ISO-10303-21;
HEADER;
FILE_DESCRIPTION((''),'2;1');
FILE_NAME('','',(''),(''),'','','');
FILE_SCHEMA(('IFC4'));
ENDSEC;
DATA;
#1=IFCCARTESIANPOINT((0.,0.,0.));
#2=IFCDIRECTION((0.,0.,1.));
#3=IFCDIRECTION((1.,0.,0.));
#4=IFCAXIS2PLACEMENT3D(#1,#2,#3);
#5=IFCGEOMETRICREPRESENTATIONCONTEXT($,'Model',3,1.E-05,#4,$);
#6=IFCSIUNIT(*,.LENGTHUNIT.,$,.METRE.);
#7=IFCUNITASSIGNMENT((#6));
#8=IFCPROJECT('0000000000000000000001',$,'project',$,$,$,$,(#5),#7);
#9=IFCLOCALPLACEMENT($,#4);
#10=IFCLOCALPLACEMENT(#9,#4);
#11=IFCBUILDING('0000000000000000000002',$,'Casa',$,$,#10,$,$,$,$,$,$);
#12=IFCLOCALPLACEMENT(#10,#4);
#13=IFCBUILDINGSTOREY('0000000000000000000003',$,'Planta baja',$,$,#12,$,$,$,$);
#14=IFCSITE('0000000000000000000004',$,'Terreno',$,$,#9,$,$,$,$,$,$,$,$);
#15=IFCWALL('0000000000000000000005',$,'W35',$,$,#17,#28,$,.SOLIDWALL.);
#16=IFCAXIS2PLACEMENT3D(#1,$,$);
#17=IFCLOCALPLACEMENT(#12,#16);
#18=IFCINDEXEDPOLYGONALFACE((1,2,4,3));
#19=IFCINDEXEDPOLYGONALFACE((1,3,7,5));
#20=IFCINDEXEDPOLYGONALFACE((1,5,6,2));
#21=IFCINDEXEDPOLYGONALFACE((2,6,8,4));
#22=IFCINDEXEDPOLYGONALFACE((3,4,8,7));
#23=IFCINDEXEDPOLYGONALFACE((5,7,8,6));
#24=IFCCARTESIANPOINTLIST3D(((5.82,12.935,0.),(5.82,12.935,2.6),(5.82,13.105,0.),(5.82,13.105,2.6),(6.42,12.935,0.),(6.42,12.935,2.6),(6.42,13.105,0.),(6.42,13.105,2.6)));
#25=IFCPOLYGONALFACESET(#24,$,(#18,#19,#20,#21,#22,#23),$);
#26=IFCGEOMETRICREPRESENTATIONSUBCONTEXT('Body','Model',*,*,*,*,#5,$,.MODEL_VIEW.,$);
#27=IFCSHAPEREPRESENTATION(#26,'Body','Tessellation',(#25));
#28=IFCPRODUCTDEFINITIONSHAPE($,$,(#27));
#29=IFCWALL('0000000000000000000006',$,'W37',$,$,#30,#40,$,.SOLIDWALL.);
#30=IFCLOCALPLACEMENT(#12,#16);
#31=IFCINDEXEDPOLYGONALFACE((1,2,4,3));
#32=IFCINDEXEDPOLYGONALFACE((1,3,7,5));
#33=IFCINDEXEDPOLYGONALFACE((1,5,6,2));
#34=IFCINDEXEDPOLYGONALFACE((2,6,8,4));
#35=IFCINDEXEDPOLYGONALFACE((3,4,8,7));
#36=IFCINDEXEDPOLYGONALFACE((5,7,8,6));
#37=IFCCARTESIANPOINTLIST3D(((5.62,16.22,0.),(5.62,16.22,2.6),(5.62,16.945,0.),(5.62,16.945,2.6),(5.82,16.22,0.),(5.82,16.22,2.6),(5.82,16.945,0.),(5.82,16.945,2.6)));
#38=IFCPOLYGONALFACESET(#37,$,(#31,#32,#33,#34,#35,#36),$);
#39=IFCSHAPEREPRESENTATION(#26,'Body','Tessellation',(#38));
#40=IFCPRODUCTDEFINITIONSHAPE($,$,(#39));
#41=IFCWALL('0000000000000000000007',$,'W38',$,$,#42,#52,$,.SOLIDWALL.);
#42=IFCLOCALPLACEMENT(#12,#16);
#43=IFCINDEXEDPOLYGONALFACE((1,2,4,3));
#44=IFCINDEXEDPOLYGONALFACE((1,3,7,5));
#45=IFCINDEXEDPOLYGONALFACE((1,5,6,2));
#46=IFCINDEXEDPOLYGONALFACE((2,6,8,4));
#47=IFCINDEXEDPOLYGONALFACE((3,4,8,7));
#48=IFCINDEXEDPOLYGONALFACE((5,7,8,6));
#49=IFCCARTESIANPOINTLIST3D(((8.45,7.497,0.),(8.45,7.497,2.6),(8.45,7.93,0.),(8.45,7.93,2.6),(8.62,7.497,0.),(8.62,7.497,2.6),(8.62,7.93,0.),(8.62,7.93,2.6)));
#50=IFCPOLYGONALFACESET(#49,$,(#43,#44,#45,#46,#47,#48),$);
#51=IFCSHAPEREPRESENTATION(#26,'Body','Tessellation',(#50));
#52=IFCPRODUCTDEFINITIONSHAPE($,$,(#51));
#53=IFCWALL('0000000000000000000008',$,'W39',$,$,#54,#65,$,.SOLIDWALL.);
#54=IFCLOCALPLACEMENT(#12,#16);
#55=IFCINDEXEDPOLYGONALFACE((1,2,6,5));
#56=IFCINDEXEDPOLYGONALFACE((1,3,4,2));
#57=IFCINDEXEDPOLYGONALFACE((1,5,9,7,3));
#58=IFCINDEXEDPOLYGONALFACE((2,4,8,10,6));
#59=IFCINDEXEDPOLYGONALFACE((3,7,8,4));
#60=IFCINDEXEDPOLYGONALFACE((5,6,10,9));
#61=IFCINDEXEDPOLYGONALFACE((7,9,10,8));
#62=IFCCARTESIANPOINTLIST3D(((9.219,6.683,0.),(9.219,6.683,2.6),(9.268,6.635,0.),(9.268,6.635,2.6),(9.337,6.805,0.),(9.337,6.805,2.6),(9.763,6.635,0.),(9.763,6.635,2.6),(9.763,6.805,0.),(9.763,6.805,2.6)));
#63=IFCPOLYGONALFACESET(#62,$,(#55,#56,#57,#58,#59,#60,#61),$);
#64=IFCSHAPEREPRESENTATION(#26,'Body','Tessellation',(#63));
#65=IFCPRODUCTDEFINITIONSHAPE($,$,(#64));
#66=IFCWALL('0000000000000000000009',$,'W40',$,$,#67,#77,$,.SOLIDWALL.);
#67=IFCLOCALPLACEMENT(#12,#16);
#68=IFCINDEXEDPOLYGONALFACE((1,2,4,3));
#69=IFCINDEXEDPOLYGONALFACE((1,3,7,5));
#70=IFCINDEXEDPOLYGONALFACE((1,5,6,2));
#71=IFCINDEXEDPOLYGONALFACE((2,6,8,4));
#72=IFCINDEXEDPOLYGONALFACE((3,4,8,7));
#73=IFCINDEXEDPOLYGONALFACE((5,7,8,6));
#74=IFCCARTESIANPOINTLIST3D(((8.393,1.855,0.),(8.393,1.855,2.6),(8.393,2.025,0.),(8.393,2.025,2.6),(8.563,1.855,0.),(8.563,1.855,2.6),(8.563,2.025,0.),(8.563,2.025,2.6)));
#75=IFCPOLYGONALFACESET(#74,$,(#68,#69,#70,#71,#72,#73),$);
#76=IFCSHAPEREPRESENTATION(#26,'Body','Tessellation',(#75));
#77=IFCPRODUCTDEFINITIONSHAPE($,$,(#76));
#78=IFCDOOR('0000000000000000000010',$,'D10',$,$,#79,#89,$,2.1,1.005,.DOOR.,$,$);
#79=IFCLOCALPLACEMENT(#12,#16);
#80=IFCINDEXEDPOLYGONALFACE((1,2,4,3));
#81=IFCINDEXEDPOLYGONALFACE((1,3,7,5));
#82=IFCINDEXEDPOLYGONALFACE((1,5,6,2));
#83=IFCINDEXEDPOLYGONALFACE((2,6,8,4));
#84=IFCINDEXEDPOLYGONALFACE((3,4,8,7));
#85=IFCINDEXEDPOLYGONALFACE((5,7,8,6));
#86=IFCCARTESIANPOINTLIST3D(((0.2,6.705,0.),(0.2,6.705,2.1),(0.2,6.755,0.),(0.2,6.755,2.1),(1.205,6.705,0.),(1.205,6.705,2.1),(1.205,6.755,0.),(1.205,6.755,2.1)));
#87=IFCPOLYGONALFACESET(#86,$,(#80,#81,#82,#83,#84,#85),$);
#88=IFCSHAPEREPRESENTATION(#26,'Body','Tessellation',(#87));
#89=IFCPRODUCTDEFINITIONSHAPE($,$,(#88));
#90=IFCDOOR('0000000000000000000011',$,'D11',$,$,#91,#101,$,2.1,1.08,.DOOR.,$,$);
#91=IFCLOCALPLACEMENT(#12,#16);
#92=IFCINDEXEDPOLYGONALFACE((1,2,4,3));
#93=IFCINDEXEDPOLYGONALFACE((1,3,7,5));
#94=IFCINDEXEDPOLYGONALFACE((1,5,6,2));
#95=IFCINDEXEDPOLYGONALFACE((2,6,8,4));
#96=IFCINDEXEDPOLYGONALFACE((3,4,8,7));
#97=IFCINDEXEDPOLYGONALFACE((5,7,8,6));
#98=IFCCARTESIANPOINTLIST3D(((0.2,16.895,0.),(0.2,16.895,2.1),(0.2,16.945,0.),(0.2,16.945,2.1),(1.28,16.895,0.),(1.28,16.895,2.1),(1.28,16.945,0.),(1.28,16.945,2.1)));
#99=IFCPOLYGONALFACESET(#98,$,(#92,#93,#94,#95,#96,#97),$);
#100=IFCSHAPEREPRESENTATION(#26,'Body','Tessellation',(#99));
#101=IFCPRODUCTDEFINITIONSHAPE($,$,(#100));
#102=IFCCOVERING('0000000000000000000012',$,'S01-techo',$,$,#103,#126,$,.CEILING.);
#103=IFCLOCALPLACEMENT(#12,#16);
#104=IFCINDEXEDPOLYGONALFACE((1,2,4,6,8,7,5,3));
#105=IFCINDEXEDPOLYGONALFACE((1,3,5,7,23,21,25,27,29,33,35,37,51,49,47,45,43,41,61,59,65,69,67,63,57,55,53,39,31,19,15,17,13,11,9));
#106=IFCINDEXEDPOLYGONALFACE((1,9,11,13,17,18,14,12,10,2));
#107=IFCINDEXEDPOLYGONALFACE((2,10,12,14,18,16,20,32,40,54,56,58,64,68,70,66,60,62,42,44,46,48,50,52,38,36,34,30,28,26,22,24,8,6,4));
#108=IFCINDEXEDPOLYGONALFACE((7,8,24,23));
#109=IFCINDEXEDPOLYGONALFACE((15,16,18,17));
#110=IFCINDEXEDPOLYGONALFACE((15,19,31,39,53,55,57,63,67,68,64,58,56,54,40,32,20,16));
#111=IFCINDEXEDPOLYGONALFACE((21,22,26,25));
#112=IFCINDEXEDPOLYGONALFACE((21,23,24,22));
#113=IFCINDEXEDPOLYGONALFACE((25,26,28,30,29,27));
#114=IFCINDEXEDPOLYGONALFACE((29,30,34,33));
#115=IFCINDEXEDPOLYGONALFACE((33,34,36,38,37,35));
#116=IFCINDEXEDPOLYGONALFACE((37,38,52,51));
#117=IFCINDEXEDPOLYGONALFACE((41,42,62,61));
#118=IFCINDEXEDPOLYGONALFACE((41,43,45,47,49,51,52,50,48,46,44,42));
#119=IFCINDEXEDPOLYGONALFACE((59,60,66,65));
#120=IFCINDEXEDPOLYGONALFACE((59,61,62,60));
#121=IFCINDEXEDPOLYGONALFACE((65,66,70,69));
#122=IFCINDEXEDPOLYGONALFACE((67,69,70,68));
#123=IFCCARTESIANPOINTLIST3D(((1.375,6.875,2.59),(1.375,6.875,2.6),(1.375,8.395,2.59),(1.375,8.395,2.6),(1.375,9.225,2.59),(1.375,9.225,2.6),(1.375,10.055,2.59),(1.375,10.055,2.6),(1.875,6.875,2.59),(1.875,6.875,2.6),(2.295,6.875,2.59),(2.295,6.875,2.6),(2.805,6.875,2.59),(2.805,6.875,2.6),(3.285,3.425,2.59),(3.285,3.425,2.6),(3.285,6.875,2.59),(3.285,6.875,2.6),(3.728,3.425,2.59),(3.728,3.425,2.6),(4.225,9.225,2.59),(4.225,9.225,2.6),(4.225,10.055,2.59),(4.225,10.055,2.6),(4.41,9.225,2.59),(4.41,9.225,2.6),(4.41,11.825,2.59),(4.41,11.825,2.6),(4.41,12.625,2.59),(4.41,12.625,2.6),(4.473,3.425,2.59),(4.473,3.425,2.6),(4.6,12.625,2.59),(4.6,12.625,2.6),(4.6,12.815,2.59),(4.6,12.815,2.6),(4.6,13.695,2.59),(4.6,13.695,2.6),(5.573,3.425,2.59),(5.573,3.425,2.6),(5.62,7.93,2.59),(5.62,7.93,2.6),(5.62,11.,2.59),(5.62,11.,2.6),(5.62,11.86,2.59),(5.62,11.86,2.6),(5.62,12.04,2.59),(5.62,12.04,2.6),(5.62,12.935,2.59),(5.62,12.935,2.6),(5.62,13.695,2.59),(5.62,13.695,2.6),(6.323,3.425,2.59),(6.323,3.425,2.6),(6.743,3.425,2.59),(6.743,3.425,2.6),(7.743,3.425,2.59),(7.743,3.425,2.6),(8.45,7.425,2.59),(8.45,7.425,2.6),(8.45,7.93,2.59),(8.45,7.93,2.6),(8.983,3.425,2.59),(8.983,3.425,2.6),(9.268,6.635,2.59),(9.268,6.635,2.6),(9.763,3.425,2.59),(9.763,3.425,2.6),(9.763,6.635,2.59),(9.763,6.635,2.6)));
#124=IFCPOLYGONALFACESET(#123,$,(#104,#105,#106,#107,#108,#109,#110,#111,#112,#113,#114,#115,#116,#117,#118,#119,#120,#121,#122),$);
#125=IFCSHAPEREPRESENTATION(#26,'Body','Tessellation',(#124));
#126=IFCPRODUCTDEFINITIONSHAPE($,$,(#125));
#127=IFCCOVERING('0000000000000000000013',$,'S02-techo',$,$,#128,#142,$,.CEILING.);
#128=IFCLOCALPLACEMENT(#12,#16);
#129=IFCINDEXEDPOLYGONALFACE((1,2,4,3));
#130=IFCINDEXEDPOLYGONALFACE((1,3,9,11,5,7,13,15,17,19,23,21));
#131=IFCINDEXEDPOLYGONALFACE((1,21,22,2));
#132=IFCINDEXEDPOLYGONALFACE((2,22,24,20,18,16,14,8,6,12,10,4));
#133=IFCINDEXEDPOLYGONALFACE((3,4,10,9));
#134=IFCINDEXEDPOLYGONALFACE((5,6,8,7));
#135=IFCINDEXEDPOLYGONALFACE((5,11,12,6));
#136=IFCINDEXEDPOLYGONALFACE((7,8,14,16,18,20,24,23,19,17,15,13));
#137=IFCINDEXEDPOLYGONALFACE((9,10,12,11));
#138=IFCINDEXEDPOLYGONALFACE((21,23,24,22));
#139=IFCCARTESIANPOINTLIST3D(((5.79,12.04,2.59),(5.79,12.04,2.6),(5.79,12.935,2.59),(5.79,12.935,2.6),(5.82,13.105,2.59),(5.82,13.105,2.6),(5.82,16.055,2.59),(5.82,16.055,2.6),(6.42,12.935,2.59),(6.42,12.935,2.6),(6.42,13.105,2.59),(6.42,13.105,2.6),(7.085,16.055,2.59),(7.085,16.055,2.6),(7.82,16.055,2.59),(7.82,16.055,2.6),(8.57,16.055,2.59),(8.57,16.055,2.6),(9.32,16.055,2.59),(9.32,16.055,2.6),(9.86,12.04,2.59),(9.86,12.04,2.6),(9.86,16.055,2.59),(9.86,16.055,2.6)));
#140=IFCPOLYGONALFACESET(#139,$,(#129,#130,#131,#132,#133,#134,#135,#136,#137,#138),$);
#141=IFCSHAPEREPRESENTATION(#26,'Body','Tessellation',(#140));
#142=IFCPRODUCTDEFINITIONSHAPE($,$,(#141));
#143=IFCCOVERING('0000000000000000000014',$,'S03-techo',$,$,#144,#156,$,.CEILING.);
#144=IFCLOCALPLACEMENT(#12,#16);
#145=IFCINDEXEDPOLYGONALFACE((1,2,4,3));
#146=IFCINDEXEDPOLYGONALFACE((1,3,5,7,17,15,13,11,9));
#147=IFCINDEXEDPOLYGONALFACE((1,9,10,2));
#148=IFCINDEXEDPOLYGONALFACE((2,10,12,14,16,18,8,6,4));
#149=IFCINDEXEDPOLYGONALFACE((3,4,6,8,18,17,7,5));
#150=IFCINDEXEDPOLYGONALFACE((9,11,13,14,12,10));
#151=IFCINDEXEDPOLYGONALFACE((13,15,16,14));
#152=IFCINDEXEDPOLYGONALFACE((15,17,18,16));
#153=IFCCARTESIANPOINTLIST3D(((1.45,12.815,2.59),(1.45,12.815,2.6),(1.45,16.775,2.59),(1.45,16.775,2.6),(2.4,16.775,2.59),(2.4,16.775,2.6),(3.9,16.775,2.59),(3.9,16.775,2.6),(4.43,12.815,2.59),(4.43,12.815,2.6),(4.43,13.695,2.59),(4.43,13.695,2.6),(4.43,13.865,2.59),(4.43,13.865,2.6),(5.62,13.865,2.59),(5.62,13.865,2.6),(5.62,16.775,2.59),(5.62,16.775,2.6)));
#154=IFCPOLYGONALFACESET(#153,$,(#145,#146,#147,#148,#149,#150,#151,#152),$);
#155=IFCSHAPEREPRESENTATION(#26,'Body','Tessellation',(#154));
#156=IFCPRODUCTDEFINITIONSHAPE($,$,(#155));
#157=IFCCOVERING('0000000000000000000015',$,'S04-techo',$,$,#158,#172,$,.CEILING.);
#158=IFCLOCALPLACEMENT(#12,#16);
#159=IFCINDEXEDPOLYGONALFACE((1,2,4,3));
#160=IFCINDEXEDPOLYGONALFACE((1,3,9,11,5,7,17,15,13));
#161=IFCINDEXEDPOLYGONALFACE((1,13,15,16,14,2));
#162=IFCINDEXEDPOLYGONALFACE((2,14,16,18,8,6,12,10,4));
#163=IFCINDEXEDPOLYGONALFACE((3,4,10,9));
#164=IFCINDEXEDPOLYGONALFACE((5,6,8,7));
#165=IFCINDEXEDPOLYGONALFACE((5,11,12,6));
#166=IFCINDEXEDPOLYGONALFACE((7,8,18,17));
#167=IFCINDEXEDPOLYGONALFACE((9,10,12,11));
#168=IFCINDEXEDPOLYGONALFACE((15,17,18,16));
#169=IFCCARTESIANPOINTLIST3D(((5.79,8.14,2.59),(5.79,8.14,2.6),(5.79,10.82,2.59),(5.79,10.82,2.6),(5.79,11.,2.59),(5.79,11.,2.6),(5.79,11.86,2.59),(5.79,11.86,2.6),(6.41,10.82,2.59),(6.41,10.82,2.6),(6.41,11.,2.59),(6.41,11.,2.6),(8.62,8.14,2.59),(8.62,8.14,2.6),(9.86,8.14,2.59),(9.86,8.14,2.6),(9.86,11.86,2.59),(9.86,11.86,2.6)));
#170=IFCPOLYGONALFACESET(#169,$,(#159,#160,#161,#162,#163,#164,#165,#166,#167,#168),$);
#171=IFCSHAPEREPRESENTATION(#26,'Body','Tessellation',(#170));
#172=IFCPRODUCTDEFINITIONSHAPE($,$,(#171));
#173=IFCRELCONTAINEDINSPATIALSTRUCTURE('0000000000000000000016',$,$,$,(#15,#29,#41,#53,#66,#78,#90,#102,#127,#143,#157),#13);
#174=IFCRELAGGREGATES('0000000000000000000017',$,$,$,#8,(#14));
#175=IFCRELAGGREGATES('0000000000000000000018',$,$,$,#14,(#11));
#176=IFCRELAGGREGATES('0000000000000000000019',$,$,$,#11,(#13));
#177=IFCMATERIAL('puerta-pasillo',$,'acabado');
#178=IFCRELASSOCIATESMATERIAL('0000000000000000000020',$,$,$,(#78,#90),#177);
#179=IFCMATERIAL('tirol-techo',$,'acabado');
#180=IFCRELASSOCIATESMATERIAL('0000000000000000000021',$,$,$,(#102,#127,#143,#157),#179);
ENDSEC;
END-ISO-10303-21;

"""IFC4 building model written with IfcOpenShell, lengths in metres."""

from ifc_helpers import new_model, si_unit, frame, origin_with_axes, place, context, subcontext, project, spatial, line, indexed_curve, outline, extrude, material, element, save


model = new_model("IFC4")

# Units and contexts
model_context = context("Model", 3, precision=1e-05, world=origin_with_axes())
body_context = subcontext(model_context, "Body", "Model", "MODEL_VIEW")
ifc_project = project(units=[si_unit("LENGTHUNIT", "METRE")], contexts=[model_context])

# Site, building, storey
site_placement = place(None, origin_with_axes())
site = spatial("IfcSite", under=ifc_project, at=site_placement, Name="Terreno")
building_placement = place(site_placement, origin_with_axes())
building = spatial("IfcBuilding", under=site, at=building_placement, Name="Casa")
storey_placement = place(building_placement, origin_with_axes())
storey = spatial("IfcBuildingStorey", under=building, at=storey_placement, Name="Planta baja")

# Walls
wall_1_placement = place(storey_placement, origin_with_axes())
element("IfcWall", 1, at=wall_1_placement, inside=storey, Name="W35", PredefinedType="SOLIDWALL", context=body_context, shape_type="SweptSolid", body=[
    extrude(outline(indexed_curve([(6.42, 13.105), (6.42, 12.935), (5.82, 12.935), (5.82, 13.105)], segments=[line(1, 2, 3, 4, 1)])), origin_with_axes(), (0.0, 0.0, 1.0), 2.6),
])
wall_2_placement = place(storey_placement, origin_with_axes())
element("IfcWall", 2, at=wall_2_placement, inside=storey, Name="W37", PredefinedType="SOLIDWALL", context=body_context, shape_type="SweptSolid", body=[
    extrude(outline(indexed_curve([(5.62, 16.945), (5.82, 16.945), (5.82, 16.22), (5.62, 16.22)], segments=[line(1, 2, 3, 4, 1)])), origin_with_axes(), (0.0, 0.0, 1.0), 2.6),
])
wall_3_placement = place(storey_placement, origin_with_axes())
element("IfcWall", 3, at=wall_3_placement, inside=storey, Name="W38", PredefinedType="SOLIDWALL", context=body_context, shape_type="SweptSolid", body=[
    extrude(outline(indexed_curve([(8.62, 7.93), (8.62, 7.497), (8.45, 7.497), (8.45, 7.93)], segments=[line(1, 2, 3, 4, 1)])), origin_with_axes(), (0.0, 0.0, 1.0), 2.6),
])
wall_4_placement = place(storey_placement, origin_with_axes())
element("IfcWall", 4, at=wall_4_placement, inside=storey, Name="W39", PredefinedType="SOLIDWALL", context=body_context, shape_type="SweptSolid", body=[
    extrude(outline(indexed_curve([(9.337, 6.805), (9.763, 6.805), (9.763, 6.635), (9.268, 6.635), (9.219, 6.683)], segments=[line(1, 2, 3, 4, 5, 1)])), origin_with_axes(), (0.0, 0.0, 1.0), 2.6),
])
wall_5_placement = place(storey_placement, origin_with_axes())
element("IfcWall", 5, at=wall_5_placement, inside=storey, Name="W40", PredefinedType="SOLIDWALL", context=body_context, shape_type="SweptSolid", body=[
    extrude(outline(indexed_curve([(8.563, 1.855), (8.393, 1.855), (8.393, 2.025), (8.563, 2.025)], segments=[line(1, 2, 3, 4, 1)])), origin_with_axes(), (0.0, 0.0, 1.0), 2.6),
])

# Doors
ifc_material_1 = material(Name="puerta-pasillo", Category="acabado")
door_1_placement = place(storey_placement, origin_with_axes())
element("IfcDoor", 6, at=door_1_placement, inside=storey, material=ifc_material_1, Name="D10", OverallHeight=2.1, OverallWidth=1.005, PredefinedType="DOOR", context=body_context, shape_type="SweptSolid", body=[
    extrude(outline(indexed_curve([(0.2, 6.705), (1.205, 6.705), (1.205, 6.755), (0.2, 6.755)], segments=[line(1, 2, 3, 4, 1)])), origin_with_axes(), (0.0, 0.0, 1.0), 2.1),
])
door_2_placement = place(storey_placement, origin_with_axes())
element("IfcDoor", 7, at=door_2_placement, inside=storey, material=ifc_material_1, Name="D11", OverallHeight=2.1, OverallWidth=1.08, PredefinedType="DOOR", context=body_context, shape_type="SweptSolid", body=[
    extrude(outline(indexed_curve([(0.2, 16.895), (1.28, 16.895), (1.28, 16.945), (0.2, 16.945)], segments=[line(1, 2, 3, 4, 1)])), origin_with_axes(), (0.0, 0.0, 1.0), 2.1),
])

# Coverings
ifc_material_2 = material(Name="tirol-techo", Category="acabado")
covering_1_placement = place(storey_placement, origin_with_axes())
element("IfcCovering", 8, at=covering_1_placement, inside=storey, material=ifc_material_2, Name="S01-techo", PredefinedType="CEILING", context=body_context, shape_type="SweptSolid", body=[
    extrude(outline(indexed_curve([(4.6, 12.625), (4.6, 12.815), (4.6, 13.695), (5.62, 13.695), (5.62, 12.935), (5.62, 12.04), (5.62, 11.86), (5.62, 11.0), (5.62, 7.93), (8.45, 7.93), (8.45, 7.425), (9.268, 6.635), (9.763, 6.635), (9.763, 3.425), (8.983, 3.425), (7.743, 3.425), (6.743, 3.425), (6.323, 3.425), (5.573, 3.425), (4.473, 3.425), (3.728, 3.425), (3.285, 3.425), (3.285, 6.875), (2.805, 6.875), (2.295, 6.875), (1.875, 6.875), (1.375, 6.875), (1.375, 8.395), (1.375, 9.225), (1.375, 10.055), (4.225, 10.055), (4.225, 9.225), (4.41, 9.225), (4.41, 11.825), (4.41, 12.625)], segments=[line(1, 2, 3, 4, 5, 6, 7, 8, 9, 10, 11, 12, 13, 14, 15, 16, 17, 18, 19, 20, 21, 22, 23, 24, 25, 26, 27, 28, 29, 30, 31, 32, 33, 34, 35, 1)])), frame((0.0, 0.0, 2.59), z_axis=(0.0, 0.0, 1.0), x_axis=(1.0, 0.0, 0.0)), (0.0, 0.0, 1.0), 0.01),
])
covering_2_placement = place(storey_placement, origin_with_axes())
element("IfcCovering", 9, at=covering_2_placement, inside=storey, material=ifc_material_2, Name="S02-techo", PredefinedType="CEILING", context=body_context, shape_type="SweptSolid", body=[
    extrude(outline(indexed_curve([(5.79, 12.935), (6.42, 12.935), (6.42, 13.105), (5.82, 13.105), (5.82, 16.055), (7.085, 16.055), (7.82, 16.055), (8.57, 16.055), (9.32, 16.055), (9.86, 16.055), (9.86, 12.04), (5.79, 12.04)], segments=[line(1, 2, 3, 4, 5, 6, 7, 8, 9, 10, 11, 12, 1)])), frame((0.0, 0.0, 2.59), z_axis=(0.0, 0.0, 1.0), x_axis=(1.0, 0.0, 0.0)), (0.0, 0.0, 1.0), 0.01),
])
covering_3_placement = place(storey_placement, origin_with_axes())
element("IfcCovering", 10, at=covering_3_placement, inside=storey, material=ifc_material_2, Name="S03-techo", PredefinedType="CEILING", context=body_context, shape_type="SweptSolid", body=[
    extrude(outline(indexed_curve([(1.45, 16.775), (2.4, 16.775), (3.9, 16.775), (5.62, 16.775), (5.62, 13.865), (4.43, 13.865), (4.43, 13.695), (4.43, 12.815), (1.45, 12.815)], segments=[line(1, 2, 3, 4, 5, 6, 7, 8, 9, 1)])), frame((0.0, 0.0, 2.59), z_axis=(0.0, 0.0, 1.0), x_axis=(1.0, 0.0, 0.0)), (0.0, 0.0, 1.0), 0.01),
])
covering_4_placement = place(storey_placement, origin_with_axes())
element("IfcCovering", 11, at=covering_4_placement, inside=storey, material=ifc_material_2, Name="S04-techo", PredefinedType="CEILING", context=body_context, shape_type="SweptSolid", body=[
    extrude(outline(indexed_curve([(6.41, 10.82), (6.41, 11.0), (5.79, 11.0), (5.79, 11.86), (9.86, 11.86), (9.86, 8.14), (8.62, 8.14), (5.79, 8.14), (5.79, 10.82)], segments=[line(1, 2, 3, 4, 5, 6, 7, 8, 9, 1)])), frame((0.0, 0.0, 2.59), z_axis=(0.0, 0.0, 1.0), x_axis=(1.0, 0.0, 0.0)), (0.0, 0.0, 1.0), 0.01),
])

save(model, "model.ifc")
